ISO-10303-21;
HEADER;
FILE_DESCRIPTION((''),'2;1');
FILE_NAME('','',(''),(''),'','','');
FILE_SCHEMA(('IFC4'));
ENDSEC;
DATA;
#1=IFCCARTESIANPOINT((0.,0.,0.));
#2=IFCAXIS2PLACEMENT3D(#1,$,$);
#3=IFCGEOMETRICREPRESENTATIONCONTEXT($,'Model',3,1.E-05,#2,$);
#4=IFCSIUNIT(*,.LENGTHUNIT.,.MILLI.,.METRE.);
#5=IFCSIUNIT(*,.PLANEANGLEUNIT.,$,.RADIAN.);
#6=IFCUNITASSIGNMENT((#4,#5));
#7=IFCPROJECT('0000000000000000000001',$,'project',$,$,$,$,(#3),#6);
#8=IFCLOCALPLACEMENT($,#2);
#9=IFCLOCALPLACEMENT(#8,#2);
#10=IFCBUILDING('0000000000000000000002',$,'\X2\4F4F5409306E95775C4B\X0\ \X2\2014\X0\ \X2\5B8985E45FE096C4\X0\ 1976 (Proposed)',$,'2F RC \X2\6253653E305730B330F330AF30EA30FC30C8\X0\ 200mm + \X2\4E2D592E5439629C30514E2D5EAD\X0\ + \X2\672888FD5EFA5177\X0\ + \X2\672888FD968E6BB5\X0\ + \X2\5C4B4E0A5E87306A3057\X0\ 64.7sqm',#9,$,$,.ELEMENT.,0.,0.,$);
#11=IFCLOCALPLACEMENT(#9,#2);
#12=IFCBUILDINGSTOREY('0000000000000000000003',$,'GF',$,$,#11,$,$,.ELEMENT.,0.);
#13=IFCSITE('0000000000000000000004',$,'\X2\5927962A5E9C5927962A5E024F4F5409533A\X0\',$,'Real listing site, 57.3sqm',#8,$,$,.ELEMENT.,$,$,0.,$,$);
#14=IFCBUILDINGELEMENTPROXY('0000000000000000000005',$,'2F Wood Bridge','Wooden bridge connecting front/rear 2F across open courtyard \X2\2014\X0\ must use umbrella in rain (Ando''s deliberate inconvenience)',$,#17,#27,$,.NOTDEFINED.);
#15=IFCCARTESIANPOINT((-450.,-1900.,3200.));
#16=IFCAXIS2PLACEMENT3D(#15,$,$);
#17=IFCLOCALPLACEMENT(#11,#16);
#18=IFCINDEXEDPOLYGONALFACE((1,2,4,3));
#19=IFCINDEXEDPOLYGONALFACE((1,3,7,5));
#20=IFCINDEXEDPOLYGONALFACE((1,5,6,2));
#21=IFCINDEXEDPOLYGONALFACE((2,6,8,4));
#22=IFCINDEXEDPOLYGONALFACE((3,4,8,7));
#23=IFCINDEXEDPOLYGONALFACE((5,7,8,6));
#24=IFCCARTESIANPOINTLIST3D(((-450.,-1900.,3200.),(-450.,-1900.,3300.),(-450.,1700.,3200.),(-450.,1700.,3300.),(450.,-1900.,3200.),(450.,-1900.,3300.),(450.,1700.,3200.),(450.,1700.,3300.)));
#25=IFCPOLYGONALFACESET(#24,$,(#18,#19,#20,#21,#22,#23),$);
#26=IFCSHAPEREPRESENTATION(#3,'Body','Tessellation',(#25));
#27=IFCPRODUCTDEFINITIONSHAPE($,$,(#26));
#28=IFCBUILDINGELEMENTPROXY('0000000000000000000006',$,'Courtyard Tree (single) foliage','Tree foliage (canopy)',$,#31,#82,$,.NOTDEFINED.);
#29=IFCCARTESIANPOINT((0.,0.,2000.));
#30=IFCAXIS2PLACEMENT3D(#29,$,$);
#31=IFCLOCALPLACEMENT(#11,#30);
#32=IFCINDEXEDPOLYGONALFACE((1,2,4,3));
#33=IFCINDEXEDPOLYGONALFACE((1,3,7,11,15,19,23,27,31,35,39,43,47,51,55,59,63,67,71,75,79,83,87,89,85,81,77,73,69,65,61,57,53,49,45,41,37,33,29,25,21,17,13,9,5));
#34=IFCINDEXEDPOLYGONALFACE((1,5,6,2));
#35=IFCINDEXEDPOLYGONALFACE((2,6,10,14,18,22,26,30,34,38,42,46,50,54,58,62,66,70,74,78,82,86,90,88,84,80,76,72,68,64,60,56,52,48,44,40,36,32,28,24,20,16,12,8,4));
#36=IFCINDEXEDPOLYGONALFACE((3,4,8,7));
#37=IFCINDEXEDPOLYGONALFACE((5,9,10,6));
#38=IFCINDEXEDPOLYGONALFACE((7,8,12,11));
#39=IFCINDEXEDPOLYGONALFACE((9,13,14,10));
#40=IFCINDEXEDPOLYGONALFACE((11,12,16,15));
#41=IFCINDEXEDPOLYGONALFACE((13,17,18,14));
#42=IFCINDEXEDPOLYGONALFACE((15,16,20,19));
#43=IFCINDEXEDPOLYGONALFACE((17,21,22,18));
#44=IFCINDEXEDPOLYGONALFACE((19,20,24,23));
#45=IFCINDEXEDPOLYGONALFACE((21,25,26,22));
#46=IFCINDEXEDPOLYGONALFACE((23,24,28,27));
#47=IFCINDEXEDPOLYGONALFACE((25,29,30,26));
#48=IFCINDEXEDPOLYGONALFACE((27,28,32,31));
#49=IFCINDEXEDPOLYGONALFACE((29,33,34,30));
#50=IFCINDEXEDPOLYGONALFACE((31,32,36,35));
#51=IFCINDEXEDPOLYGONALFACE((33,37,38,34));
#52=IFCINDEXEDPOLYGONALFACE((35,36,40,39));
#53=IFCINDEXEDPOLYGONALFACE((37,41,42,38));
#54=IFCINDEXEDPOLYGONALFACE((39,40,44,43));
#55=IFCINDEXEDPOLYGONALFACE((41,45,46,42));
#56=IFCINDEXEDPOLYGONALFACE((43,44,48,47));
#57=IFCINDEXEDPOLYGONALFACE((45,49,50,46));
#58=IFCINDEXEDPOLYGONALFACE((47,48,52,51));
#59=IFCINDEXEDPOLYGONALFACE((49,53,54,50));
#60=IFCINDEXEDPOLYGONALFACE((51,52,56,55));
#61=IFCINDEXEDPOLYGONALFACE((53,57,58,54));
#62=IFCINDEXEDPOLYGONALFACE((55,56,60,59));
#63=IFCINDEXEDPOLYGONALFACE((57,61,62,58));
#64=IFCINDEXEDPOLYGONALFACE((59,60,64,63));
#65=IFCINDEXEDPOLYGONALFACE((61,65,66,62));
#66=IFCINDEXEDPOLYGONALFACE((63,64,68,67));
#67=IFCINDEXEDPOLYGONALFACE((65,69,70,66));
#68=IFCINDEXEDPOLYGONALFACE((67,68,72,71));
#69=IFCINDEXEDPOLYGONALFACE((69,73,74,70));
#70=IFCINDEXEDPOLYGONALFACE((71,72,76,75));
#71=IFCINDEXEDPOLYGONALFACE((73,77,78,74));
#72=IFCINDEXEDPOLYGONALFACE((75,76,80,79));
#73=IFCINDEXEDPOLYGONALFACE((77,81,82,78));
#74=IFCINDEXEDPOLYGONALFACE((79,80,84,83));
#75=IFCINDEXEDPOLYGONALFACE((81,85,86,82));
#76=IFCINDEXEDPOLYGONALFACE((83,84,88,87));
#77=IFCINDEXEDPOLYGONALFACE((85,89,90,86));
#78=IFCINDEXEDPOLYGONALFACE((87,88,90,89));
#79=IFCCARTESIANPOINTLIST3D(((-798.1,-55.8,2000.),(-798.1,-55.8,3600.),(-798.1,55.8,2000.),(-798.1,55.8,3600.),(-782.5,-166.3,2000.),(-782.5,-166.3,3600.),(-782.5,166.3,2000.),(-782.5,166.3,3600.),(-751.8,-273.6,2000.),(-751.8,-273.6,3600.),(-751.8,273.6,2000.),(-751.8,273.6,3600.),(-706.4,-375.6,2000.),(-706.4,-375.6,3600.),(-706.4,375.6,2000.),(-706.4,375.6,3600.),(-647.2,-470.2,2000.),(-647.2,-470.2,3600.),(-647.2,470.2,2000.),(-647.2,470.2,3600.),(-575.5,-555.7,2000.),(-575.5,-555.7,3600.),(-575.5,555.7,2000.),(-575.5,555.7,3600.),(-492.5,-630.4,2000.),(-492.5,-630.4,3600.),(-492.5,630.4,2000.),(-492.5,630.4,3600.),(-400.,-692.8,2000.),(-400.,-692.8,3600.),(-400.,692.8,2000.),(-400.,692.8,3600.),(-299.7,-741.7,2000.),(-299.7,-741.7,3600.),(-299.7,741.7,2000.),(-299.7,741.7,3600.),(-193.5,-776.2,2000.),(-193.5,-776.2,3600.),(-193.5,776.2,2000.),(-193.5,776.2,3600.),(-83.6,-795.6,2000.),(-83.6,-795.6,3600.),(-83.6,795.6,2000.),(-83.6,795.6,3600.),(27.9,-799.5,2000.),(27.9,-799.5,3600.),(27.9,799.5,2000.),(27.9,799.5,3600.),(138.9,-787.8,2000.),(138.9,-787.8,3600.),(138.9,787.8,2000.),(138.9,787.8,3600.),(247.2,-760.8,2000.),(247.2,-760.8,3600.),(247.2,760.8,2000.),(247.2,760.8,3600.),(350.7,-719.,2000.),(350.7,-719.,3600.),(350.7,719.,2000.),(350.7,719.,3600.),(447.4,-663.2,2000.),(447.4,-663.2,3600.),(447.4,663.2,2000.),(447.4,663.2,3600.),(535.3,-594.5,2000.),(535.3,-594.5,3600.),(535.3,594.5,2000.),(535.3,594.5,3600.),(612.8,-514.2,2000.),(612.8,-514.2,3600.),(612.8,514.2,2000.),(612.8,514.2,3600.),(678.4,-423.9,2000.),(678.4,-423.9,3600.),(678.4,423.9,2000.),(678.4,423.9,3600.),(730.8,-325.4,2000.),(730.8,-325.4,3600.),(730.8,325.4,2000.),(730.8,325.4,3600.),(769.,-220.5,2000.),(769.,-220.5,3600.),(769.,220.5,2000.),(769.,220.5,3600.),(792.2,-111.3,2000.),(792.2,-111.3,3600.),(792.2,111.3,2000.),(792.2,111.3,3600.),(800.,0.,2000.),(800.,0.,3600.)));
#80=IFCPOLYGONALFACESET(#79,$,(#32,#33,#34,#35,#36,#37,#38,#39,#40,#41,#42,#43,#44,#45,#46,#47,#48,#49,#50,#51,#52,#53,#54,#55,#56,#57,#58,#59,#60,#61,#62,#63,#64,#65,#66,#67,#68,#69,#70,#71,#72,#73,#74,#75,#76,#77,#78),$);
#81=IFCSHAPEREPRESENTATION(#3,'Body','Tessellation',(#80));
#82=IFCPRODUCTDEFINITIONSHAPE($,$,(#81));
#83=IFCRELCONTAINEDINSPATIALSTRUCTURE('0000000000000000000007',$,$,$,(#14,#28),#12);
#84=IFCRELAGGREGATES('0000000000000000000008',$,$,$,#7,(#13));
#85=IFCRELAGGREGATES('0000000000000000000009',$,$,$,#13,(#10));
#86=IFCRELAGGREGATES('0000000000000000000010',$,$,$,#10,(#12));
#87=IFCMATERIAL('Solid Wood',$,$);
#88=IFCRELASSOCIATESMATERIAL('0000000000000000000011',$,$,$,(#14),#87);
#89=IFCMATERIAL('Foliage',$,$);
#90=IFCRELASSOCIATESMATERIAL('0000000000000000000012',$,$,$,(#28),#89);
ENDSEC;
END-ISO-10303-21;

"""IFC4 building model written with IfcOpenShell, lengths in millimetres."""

from ifc_helpers import new_model, si_unit, frame, frame_2d, origin, origin_2d, place, context, project, spatial, rectangle, circle, extrude, material, element, save


model = new_model("IFC4")

# Units and contexts
model_context = context("Model", 3, precision=1e-05, world=origin())
ifc_project = project(units=[si_unit("LENGTHUNIT", "METRE", prefix="MILLI"), si_unit("PLANEANGLEUNIT", "RADIAN")], contexts=[model_context])

# Site, building, storey
site_placement = place(None, origin())
site = spatial("IfcSite", under=ifc_project, at=site_placement, Name="大阪府大阪市住吉区", ObjectType="Real listing site, 57.3sqm", CompositionType="ELEMENT", RefElevation=0.0)
building_placement = place(site_placement, origin())
building = spatial("IfcBuilding", under=site, at=building_placement, Name="住吉の長屋 — 安藤忠雄 1976 (Proposed)", ObjectType="2F RC 打放しコンクリート 200mm + 中央吹抜け中庭 + 木製建具 + 木製階段 + 屋上庇なし 64.7sqm", CompositionType="ELEMENT", ElevationOfRefHeight=0.0, ElevationOfTerrain=0.0)
storey_placement = place(building_placement, origin())
storey = spatial("IfcBuildingStorey", under=building, at=storey_placement, Name="GF", CompositionType="ELEMENT", Elevation=0.0)

# Shared definitions
ifc_material_1 = material(Name="Solid Wood")

# Building element proxies
proxy_1_placement = place(storey_placement, frame((-450.0, -1900.0, 3200.0)))
element("IfcBuildingElementProxy", 1, at=proxy_1_placement, inside=storey, material=ifc_material_1, Name="2F Wood Bridge", Description="Wooden bridge connecting front/rear 2F across open courtyard — must use umbrella in rain (Ando's deliberate inconvenience)", PredefinedType="NOTDEFINED", context=model_context, shape_type="SweptSolid", body=[
    extrude(rectangle(XDim=900.0, YDim=3600.0, at=frame_2d((450.0, 1800.0))), frame((-450.0, -1900.0, 3200.0)), (0.0, 0.0, 1.0), 100.0),
])
ifc_material_2 = material(Name="Foliage")
proxy_2_placement = place(storey_placement, frame((0.0, 0.0, 2000.0)))
element("IfcBuildingElementProxy", 2, at=proxy_2_placement, inside=storey, material=ifc_material_2, Name="Courtyard Tree (single) foliage", Description="Tree foliage (canopy)", PredefinedType="NOTDEFINED", context=model_context, shape_type="SweptSolid", body=[
    extrude(circle(Radius=800.0, at=origin_2d()), frame((0.0, 0.0, 2000.0)), (0.0, 0.0, 1.0), 1600.0),
])

save(model, "model.ifc")
